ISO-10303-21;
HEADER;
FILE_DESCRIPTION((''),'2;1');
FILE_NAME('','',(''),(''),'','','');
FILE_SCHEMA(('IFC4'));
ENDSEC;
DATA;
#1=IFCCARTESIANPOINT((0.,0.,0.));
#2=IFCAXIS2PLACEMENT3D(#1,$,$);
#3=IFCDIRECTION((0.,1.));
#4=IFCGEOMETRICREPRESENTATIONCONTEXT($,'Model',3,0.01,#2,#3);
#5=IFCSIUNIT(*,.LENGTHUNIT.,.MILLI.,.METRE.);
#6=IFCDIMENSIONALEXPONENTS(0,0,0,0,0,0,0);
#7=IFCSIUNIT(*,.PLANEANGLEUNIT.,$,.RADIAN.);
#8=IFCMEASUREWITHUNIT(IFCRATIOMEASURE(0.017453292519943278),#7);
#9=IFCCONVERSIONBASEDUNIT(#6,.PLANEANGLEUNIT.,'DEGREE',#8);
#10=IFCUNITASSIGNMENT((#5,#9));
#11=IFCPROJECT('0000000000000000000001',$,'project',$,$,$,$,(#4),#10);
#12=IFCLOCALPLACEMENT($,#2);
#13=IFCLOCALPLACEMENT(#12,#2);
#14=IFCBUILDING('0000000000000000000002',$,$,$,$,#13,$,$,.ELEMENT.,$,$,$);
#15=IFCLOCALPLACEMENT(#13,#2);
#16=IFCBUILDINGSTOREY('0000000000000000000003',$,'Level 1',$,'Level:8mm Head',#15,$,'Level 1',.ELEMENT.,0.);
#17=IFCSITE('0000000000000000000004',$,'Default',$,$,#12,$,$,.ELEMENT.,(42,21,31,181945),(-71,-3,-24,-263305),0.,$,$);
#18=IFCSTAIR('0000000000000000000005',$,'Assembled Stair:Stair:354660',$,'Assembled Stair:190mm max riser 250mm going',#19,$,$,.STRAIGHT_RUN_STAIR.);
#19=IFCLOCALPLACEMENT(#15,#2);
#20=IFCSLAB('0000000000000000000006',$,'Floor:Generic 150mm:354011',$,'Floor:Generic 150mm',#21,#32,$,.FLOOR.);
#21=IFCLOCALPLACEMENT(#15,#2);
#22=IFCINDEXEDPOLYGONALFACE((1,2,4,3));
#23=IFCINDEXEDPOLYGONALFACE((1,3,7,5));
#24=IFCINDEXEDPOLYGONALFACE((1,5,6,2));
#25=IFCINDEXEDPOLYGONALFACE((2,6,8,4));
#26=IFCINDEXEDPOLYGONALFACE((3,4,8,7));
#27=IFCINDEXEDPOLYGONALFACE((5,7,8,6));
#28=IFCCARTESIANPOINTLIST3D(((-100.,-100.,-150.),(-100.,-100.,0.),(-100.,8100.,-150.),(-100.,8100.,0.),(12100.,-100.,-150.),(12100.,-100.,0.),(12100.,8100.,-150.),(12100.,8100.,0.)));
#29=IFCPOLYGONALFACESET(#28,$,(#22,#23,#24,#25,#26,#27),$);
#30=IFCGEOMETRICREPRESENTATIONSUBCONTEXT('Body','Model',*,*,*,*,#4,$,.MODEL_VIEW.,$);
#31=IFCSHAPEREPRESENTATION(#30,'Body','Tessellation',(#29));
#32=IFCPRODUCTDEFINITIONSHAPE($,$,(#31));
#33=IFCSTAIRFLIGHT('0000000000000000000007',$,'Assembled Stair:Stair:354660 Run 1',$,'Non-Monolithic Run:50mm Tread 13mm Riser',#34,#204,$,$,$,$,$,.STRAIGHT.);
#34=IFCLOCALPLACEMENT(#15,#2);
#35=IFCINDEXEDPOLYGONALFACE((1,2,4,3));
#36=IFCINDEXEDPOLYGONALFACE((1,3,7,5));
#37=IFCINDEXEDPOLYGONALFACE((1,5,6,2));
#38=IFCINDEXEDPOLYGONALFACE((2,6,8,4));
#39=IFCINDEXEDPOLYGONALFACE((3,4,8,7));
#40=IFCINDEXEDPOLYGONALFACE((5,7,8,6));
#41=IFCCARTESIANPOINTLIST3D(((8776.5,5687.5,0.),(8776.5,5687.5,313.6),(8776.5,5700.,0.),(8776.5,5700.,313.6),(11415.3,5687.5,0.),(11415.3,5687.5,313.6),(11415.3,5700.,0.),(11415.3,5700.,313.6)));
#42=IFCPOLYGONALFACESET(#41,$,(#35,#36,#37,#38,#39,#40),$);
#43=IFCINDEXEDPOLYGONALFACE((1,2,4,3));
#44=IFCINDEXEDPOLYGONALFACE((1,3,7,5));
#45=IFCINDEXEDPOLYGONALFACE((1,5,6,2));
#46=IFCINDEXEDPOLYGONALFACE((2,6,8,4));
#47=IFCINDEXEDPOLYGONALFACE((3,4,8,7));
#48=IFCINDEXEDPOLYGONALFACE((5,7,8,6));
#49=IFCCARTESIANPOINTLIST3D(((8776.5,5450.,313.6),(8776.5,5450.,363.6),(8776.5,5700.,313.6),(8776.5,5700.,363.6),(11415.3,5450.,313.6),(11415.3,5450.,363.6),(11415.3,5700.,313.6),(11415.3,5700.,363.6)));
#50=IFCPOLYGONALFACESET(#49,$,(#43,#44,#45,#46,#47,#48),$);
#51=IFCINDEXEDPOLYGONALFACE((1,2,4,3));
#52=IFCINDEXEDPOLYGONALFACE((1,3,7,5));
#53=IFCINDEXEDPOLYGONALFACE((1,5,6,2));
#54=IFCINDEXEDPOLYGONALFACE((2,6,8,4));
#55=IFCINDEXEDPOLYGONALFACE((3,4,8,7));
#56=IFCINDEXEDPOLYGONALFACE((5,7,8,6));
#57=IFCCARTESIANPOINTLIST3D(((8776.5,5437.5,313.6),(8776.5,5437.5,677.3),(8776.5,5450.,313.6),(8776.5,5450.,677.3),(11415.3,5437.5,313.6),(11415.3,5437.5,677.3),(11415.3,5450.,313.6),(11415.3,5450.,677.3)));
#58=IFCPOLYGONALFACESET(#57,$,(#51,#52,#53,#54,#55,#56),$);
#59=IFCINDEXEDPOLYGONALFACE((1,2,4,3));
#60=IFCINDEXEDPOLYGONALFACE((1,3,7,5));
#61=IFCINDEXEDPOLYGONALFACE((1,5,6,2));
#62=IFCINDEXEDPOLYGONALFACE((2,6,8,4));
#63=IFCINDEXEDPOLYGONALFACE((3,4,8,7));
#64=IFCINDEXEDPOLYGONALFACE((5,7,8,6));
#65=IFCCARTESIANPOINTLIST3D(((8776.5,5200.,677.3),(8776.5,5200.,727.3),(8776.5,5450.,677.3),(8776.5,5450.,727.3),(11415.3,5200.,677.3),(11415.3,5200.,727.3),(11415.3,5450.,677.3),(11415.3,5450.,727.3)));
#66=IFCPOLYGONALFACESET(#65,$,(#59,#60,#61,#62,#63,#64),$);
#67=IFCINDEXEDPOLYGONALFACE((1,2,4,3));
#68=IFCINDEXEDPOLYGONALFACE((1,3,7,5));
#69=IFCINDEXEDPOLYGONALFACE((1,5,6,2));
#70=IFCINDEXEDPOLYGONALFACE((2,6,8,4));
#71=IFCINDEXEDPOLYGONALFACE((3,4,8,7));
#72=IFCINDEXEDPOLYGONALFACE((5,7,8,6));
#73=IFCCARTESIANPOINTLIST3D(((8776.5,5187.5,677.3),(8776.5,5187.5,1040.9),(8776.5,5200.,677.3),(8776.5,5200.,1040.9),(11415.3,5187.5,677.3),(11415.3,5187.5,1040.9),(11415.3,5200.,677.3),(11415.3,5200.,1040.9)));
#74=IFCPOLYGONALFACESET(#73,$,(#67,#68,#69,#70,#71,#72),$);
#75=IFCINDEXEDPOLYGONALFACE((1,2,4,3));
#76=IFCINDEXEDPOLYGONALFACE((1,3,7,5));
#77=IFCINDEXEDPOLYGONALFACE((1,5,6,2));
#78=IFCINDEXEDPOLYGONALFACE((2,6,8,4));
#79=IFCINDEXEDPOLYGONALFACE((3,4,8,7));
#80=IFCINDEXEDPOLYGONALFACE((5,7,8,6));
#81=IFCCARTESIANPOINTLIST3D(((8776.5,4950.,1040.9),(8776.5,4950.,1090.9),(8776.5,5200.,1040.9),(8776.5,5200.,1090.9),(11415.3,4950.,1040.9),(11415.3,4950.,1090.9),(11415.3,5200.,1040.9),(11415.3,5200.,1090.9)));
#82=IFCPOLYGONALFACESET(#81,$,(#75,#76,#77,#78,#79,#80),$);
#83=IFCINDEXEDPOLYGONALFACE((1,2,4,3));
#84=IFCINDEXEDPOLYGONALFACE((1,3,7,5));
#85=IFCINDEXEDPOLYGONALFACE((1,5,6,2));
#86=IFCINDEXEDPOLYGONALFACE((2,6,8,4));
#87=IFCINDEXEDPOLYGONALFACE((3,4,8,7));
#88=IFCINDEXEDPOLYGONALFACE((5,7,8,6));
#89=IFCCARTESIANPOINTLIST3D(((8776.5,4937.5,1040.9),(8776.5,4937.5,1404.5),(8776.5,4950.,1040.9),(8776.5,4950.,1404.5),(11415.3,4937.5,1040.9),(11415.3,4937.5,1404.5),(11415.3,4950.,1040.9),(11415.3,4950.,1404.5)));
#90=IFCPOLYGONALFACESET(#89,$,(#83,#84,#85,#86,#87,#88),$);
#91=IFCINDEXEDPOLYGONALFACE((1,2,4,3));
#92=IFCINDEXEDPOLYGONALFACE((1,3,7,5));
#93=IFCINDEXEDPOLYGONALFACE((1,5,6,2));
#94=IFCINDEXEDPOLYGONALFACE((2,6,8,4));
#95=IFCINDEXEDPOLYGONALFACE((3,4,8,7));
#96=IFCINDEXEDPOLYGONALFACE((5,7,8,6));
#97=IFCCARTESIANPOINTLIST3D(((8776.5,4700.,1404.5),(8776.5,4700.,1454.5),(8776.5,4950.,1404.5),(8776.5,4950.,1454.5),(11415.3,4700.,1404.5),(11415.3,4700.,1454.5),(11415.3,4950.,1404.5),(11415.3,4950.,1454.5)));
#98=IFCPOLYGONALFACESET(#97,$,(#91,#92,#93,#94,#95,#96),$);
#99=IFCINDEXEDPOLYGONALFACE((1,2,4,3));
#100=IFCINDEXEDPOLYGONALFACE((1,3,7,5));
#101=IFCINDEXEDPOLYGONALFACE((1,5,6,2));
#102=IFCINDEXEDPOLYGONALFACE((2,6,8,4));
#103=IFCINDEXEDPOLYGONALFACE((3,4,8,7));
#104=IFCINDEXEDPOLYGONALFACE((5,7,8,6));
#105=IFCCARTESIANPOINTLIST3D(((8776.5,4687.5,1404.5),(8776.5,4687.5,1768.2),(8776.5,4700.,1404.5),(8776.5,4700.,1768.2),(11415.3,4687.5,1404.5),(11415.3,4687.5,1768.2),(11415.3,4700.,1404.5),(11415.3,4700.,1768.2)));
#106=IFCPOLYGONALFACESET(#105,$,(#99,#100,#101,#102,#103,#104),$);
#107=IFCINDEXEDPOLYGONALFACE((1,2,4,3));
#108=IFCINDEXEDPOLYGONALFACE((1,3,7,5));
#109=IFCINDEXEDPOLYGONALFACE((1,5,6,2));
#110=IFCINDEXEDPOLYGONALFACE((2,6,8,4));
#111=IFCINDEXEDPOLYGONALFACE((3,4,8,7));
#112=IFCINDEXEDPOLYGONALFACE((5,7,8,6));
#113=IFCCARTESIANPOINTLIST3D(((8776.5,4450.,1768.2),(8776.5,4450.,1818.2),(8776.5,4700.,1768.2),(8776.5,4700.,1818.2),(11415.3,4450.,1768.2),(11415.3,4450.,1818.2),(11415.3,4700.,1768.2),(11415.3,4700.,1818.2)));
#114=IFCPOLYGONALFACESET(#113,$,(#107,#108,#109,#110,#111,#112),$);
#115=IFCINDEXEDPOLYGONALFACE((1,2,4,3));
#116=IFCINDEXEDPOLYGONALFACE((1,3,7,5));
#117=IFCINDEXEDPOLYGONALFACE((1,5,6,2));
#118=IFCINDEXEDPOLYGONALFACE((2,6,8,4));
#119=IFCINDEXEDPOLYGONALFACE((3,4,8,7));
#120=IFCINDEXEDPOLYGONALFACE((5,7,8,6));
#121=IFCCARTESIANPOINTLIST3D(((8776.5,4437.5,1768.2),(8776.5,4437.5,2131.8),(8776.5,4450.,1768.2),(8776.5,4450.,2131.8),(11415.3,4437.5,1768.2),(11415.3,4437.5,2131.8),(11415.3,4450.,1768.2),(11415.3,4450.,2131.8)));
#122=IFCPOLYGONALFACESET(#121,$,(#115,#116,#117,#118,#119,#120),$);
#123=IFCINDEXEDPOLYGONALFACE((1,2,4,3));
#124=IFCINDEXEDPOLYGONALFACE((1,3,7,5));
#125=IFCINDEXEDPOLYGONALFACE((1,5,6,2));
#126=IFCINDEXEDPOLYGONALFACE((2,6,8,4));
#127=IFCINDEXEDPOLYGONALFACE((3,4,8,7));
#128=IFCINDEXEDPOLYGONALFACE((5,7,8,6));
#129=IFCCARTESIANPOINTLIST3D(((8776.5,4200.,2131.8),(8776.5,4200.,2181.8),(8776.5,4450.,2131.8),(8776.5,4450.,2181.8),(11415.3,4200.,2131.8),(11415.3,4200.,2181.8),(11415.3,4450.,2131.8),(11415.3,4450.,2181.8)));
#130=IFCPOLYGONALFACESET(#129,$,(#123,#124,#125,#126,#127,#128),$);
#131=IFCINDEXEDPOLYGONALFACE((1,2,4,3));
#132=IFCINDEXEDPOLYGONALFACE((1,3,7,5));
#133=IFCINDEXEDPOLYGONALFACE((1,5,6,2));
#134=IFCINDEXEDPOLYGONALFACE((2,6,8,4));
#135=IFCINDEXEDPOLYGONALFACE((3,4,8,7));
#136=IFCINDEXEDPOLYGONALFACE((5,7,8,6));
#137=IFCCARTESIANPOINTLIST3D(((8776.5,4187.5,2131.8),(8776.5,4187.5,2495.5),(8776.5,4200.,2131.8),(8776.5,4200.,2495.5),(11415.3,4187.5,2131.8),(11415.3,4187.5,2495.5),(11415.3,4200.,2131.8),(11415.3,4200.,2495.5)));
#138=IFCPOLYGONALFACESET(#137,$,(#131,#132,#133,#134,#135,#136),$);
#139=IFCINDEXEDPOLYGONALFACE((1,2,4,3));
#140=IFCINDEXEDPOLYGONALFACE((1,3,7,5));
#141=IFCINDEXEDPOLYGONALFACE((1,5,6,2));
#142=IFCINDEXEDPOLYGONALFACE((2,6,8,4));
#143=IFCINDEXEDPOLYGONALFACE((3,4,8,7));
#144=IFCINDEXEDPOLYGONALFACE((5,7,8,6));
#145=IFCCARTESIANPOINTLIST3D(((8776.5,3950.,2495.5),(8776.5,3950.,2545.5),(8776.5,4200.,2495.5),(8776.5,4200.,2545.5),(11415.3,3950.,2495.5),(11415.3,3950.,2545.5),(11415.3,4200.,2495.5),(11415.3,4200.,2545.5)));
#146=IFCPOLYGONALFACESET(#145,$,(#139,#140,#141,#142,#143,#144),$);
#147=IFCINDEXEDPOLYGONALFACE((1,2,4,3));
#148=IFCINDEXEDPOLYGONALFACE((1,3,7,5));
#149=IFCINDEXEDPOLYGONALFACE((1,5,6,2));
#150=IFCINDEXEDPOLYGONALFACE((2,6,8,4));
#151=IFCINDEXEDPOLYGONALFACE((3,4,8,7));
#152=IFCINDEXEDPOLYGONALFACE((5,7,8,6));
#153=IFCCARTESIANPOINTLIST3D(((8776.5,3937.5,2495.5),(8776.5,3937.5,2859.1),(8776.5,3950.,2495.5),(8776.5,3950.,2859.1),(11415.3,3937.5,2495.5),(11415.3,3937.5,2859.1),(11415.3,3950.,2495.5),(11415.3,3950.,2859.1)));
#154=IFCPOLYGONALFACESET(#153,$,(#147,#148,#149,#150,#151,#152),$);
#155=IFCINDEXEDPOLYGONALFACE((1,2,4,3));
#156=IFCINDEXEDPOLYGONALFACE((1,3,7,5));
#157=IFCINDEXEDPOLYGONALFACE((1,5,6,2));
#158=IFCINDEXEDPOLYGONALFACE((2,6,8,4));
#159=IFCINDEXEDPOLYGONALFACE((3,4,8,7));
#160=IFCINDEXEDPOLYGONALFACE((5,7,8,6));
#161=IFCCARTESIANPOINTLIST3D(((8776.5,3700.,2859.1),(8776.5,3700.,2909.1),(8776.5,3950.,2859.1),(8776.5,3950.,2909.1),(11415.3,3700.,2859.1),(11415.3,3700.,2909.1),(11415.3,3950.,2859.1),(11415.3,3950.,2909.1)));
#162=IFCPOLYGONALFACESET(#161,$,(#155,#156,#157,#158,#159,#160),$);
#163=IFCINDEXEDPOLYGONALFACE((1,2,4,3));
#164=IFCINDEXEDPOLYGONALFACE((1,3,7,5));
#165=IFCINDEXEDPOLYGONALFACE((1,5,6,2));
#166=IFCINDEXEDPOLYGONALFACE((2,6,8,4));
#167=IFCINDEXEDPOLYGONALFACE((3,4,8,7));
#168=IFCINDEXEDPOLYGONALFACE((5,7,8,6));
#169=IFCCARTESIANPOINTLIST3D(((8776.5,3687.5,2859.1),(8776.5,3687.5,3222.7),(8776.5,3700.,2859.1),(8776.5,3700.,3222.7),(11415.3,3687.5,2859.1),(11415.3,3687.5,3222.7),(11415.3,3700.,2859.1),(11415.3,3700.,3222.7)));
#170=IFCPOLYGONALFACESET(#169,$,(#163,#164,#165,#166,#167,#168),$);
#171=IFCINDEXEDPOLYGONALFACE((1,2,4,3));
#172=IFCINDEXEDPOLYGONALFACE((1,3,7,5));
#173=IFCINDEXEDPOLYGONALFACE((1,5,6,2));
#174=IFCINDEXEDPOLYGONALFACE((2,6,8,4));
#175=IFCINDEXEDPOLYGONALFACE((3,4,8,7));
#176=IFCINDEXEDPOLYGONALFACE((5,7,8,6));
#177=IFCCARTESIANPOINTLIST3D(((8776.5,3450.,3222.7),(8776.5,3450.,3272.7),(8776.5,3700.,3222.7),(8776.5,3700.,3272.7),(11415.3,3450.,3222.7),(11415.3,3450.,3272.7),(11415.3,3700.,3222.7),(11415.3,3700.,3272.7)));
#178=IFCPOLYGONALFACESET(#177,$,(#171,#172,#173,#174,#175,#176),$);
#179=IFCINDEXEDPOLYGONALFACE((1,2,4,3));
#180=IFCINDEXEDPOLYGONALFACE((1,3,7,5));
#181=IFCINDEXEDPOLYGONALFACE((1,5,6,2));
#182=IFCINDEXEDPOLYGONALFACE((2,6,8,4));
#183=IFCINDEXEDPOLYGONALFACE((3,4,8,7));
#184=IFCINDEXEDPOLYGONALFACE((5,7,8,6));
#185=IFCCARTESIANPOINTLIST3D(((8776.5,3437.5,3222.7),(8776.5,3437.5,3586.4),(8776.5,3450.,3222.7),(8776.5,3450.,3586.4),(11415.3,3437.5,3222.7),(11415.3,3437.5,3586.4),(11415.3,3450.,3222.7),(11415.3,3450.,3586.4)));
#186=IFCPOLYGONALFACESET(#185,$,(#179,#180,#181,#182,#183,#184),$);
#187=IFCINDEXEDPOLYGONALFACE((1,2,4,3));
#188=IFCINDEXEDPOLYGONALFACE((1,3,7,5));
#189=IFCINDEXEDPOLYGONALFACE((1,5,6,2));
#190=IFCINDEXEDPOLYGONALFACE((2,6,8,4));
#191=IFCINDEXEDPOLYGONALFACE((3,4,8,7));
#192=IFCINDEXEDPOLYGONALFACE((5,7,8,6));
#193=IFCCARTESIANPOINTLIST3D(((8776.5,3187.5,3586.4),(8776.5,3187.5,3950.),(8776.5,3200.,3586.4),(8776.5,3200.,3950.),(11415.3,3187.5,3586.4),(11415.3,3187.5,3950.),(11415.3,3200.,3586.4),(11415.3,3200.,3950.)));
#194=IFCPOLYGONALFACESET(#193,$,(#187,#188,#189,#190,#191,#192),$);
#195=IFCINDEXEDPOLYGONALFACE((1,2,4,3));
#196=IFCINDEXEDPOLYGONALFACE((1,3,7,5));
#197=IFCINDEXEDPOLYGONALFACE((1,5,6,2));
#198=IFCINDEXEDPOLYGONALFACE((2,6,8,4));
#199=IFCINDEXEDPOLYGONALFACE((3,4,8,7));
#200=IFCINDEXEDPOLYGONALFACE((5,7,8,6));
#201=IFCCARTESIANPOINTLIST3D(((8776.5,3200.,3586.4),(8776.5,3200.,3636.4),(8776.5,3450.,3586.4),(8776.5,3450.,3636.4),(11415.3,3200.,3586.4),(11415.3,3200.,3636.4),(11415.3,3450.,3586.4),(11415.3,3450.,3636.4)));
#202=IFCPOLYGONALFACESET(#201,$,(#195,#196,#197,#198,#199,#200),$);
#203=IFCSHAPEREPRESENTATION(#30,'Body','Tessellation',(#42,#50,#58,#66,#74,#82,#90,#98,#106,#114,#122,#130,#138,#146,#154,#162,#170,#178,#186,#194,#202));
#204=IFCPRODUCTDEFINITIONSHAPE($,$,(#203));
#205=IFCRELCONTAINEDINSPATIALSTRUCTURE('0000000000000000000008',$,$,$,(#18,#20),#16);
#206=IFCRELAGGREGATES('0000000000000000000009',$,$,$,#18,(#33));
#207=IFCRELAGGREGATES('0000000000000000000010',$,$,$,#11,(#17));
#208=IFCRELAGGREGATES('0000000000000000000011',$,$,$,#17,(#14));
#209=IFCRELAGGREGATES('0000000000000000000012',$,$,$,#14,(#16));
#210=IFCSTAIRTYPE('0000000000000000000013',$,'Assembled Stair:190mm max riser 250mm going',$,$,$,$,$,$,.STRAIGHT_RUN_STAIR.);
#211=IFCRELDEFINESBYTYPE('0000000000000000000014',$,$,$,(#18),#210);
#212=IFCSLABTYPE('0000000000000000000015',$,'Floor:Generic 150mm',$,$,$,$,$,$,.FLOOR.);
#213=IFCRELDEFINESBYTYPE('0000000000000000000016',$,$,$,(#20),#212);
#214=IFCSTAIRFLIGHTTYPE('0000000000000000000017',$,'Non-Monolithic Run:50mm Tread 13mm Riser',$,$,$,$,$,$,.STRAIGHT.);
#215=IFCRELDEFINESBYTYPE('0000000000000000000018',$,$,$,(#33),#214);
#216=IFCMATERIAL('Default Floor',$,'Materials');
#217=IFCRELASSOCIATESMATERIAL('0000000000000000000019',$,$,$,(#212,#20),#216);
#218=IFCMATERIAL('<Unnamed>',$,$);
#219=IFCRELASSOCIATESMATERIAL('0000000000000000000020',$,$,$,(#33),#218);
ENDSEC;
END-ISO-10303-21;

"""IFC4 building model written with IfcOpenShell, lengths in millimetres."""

from ifc_helpers import new_model, entity, si_unit, converted_unit, direction, frame, origin, place, context, subcontext, project, spatial, indexed_curve, outline, extrude, material, type_object, element, aggregate, save


model = new_model("IFC4")

# Units and contexts
model_context = context("Model", 3, precision=0.01, world=origin(), true_north=direction((0.0, 1.0)))
body_context = subcontext(model_context, "Body", "Model", "MODEL_VIEW")
ifc_project = project(units=[si_unit("LENGTHUNIT", "METRE", prefix="MILLI"), converted_unit("PLANEANGLEUNIT", "DEGREE", entity("IfcRatioMeasure", 0.017453292519943278), si_unit("PLANEANGLEUNIT", "RADIAN"), dimensions=[0, 0, 0, 0, 0, 0, 0])], contexts=[model_context])

# Site, building, storey
site_placement = place(None, origin())
site = spatial("IfcSite", under=ifc_project, at=site_placement, Name="Default", CompositionType="ELEMENT", RefLatitude=(42, 21, 31, 181945), RefLongitude=(-71, -3, -24, -263305), RefElevation=0.0)
building_placement = place(site_placement, origin())
building = spatial("IfcBuilding", under=site, at=building_placement, CompositionType="ELEMENT")
storey_placement = place(building_placement, origin())
storey = spatial("IfcBuildingStorey", under=building, at=storey_placement, Name="Level 1", ObjectType="Level:8mm Head", LongName="Level 1", CompositionType="ELEMENT", Elevation=0.0)

# Stair
stair_type = type_object("IfcStairType", Name="Assembled Stair:190mm max riser 250mm going", PredefinedType="STRAIGHT_RUN_STAIR")
stair_placement = place(storey_placement, origin())
stair = element("IfcStair", 1, at=stair_placement, inside=storey, type_object=stair_type, Name="Assembled Stair:Stair:354660", ObjectType="Assembled Stair:190mm max riser 250mm going", PredefinedType="STRAIGHT_RUN_STAIR")
ifc_material_1 = material(Name="<Unnamed>")

# Slab
ifc_material_2 = material(Name="Default Floor", Category="Materials")
slab_type = type_object("IfcSlabType", Name="Floor:Generic 150mm", PredefinedType="FLOOR", material=ifc_material_2)
slab_placement = place(storey_placement, origin())
element("IfcSlab", 2, at=slab_placement, inside=storey, type_object=slab_type, material=ifc_material_2, Name="Floor:Generic 150mm:354011", ObjectType="Floor:Generic 150mm", PredefinedType="FLOOR", context=body_context, shape_type="SweptSolid", body=[
    extrude(outline(indexed_curve([(-4100.0, -6100.0), (4100.0, -6100.0), (4100.0, 6100.0), (-4100.0, 6100.0), (-4100.0, -6100.0)], self_intersect=False)), frame((6000.0, 4000.0, 0.0), z_axis=(0.0, 0.0, -1.0), x_axis=(0.0, 1.0, 0.0)), (0.0, 0.0, 1.0), 150.0),
])

# Stair flight
stair_flight_type = type_object("IfcStairFlightType", Name="Non-Monolithic Run:50mm Tread 13mm Riser", PredefinedType="STRAIGHT")
stair_flight_placement = place(stair_placement, origin())
stair_flight = element("IfcStairFlight", 3, at=stair_flight_placement, type_object=stair_flight_type, material=ifc_material_1, Name="Assembled Stair:Stair:354660 Run 1", ObjectType="Non-Monolithic Run:50mm Tread 13mm Riser", PredefinedType="STRAIGHT", context=body_context, shape_type="SweptSolid", body=[
    extrude(outline(indexed_curve([(-1319.4, -6.2), (1319.4, -6.2), (1319.4, 6.3), (-1319.4, 6.3), (-1319.4, -6.2)], self_intersect=False)), frame((10095.9, 5693.7, 0.0)), (0.0, 0.0, 1.0), 313.6),
    extrude(outline(indexed_curve([(-125.0, -1319.4), (125.0, -1319.4), (125.0, 1319.4), (-125.0, 1319.4), (-125.0, -1319.4)], self_intersect=False)), frame((10095.9, 5575.0, 313.6), z_axis=(0.0, 0.0, 1.0), x_axis=(0.0, 1.0, 0.0)), (0.0, 0.0, 1.0), 50.0),
    extrude(outline(indexed_curve([(-1319.4, -6.2), (1319.4, -6.2), (1319.4, 6.3), (-1319.4, 6.3), (-1319.4, -6.2)], self_intersect=False)), frame((10095.9, 5443.7, 313.6)), (0.0, 0.0, 1.0), 363.6),
    extrude(outline(indexed_curve([(-125.0, -1319.4), (125.0, -1319.4), (125.0, 1319.4), (-125.0, 1319.4), (-125.0, -1319.4)], self_intersect=False)), frame((10095.9, 5325.0, 677.3), z_axis=(0.0, 0.0, 1.0), x_axis=(0.0, 1.0, 0.0)), (0.0, 0.0, 1.0), 50.0),
    extrude(outline(indexed_curve([(-1319.4, -6.3), (1319.4, -6.3), (1319.4, 6.2), (-1319.4, 6.2), (-1319.4, -6.3)], self_intersect=False)), frame((10095.9, 5193.7, 677.3)), (0.0, 0.0, 1.0), 363.6),
    extrude(outline(indexed_curve([(-125.0, -1319.4), (125.0, -1319.4), (125.0, 1319.4), (-125.0, 1319.4), (-125.0, -1319.4)], self_intersect=False)), frame((10095.9, 5075.0, 1040.9), z_axis=(0.0, 0.0, 1.0), x_axis=(0.0, 1.0, 0.0)), (0.0, 0.0, 1.0), 50.0),
    extrude(outline(indexed_curve([(-1319.4, -6.2), (1319.4, -6.2), (1319.4, 6.3), (-1319.4, 6.3), (-1319.4, -6.2)], self_intersect=False)), frame((10095.9, 4943.7, 1040.9)), (0.0, 0.0, 1.0), 363.6),
    extrude(outline(indexed_curve([(-125.0, -1319.4), (125.0, -1319.4), (125.0, 1319.4), (-125.0, 1319.4), (-125.0, -1319.4)], self_intersect=False)), frame((10095.9, 4825.0, 1404.5), z_axis=(0.0, 0.0, 1.0), x_axis=(0.0, 1.0, 0.0)), (0.0, 0.0, 1.0), 50.0),
    extrude(outline(indexed_curve([(-1319.4, -6.3), (1319.4, -6.3), (1319.4, 6.3), (-1319.4, 6.3), (-1319.4, -6.3)], self_intersect=False)), frame((10095.9, 4693.7, 1404.5)), (0.0, 0.0, 1.0), 363.6),
    extrude(outline(indexed_curve([(-125.0, -1319.4), (125.0, -1319.4), (125.0, 1319.4), (-125.0, 1319.4), (-125.0, -1319.4)], self_intersect=False)), frame((10095.9, 4575.0, 1768.2), z_axis=(0.0, 0.0, 1.0), x_axis=(0.0, 1.0, 0.0)), (0.0, 0.0, 1.0), 50.0),
    extrude(outline(indexed_curve([(-1319.4, -6.2), (1319.4, -6.2), (1319.4, 6.3), (-1319.4, 6.3), (-1319.4, -6.2)], self_intersect=False)), frame((10095.9, 4443.7, 1768.2)), (0.0, 0.0, 1.0), 363.6),
    extrude(outline(indexed_curve([(-125.0, -1319.4), (125.0, -1319.4), (125.0, 1319.4), (-125.0, 1319.4), (-125.0, -1319.4)], self_intersect=False)), frame((10095.9, 4325.0, 2131.8), z_axis=(0.0, 0.0, 1.0), x_axis=(0.0, 1.0, 0.0)), (0.0, 0.0, 1.0), 50.0),
    extrude(outline(indexed_curve([(-1319.4, -6.3), (1319.4, -6.3), (1319.4, 6.3), (-1319.4, 6.3), (-1319.4, -6.3)], self_intersect=False)), frame((10095.9, 4193.7, 2131.8)), (0.0, 0.0, 1.0), 363.6),
    extrude(outline(indexed_curve([(-125.0, -1319.4), (125.0, -1319.4), (125.0, 1319.4), (-125.0, 1319.4), (-125.0, -1319.4)], self_intersect=False)), frame((10095.9, 4075.0, 2495.5), z_axis=(0.0, 0.0, 1.0), x_axis=(0.0, 1.0, 0.0)), (0.0, 0.0, 1.0), 50.0),
    extrude(outline(indexed_curve([(-1319.4, -6.3), (1319.4, -6.3), (1319.4, 6.2), (-1319.4, 6.2), (-1319.4, -6.3)], self_intersect=False)), frame((10095.9, 3943.7, 2495.5)), (0.0, 0.0, 1.0), 363.6),
    extrude(outline(indexed_curve([(-125.0, -1319.4), (125.0, -1319.4), (125.0, 1319.4), (-125.0, 1319.4), (-125.0, -1319.4)], self_intersect=False)), frame((10095.9, 3825.0, 2859.1), z_axis=(0.0, 0.0, 1.0), x_axis=(0.0, 1.0, 0.0)), (0.0, 0.0, 1.0), 50.0),
    extrude(outline(indexed_curve([(-1319.4, -6.3), (1319.4, -6.3), (1319.4, 6.2), (-1319.4, 6.2), (-1319.4, -6.3)], self_intersect=False)), frame((10095.9, 3693.7, 2859.1)), (0.0, 0.0, 1.0), 363.6),
    extrude(outline(indexed_curve([(-125.0, -1319.4), (125.0, -1319.4), (125.0, 1319.4), (-125.0, 1319.4), (-125.0, -1319.4)], self_intersect=False)), frame((10095.9, 3575.0, 3222.7), z_axis=(0.0, 0.0, 1.0), x_axis=(0.0, 1.0, 0.0)), (0.0, 0.0, 1.0), 50.0),
    extrude(outline(indexed_curve([(-1319.4, -6.3), (1319.4, -6.3), (1319.4, 6.3), (-1319.4, 6.3), (-1319.4, -6.3)], self_intersect=False)), frame((10095.9, 3443.7, 3222.7)), (0.0, 0.0, 1.0), 363.6),
    extrude(outline(indexed_curve([(-1319.4, -6.3), (1319.4, -6.3), (1319.4, 6.2), (-1319.4, 6.2), (-1319.4, -6.3)], self_intersect=False)), frame((10095.9, 3193.7, 3586.4)), (0.0, 0.0, 1.0), 363.6),
    extrude(outline(indexed_curve([(-125.0, -1319.4), (125.0, -1319.4), (125.0, 1319.4), (-125.0, 1319.4), (-125.0, -1319.4)], self_intersect=False)), frame((10095.9, 3325.0, 3586.4), z_axis=(0.0, 0.0, 1.0), x_axis=(0.0, 1.0, 0.0)), (0.0, 0.0, 1.0), 50.0),
])

aggregate(stair, [stair_flight])

save(model, "model.ifc")
